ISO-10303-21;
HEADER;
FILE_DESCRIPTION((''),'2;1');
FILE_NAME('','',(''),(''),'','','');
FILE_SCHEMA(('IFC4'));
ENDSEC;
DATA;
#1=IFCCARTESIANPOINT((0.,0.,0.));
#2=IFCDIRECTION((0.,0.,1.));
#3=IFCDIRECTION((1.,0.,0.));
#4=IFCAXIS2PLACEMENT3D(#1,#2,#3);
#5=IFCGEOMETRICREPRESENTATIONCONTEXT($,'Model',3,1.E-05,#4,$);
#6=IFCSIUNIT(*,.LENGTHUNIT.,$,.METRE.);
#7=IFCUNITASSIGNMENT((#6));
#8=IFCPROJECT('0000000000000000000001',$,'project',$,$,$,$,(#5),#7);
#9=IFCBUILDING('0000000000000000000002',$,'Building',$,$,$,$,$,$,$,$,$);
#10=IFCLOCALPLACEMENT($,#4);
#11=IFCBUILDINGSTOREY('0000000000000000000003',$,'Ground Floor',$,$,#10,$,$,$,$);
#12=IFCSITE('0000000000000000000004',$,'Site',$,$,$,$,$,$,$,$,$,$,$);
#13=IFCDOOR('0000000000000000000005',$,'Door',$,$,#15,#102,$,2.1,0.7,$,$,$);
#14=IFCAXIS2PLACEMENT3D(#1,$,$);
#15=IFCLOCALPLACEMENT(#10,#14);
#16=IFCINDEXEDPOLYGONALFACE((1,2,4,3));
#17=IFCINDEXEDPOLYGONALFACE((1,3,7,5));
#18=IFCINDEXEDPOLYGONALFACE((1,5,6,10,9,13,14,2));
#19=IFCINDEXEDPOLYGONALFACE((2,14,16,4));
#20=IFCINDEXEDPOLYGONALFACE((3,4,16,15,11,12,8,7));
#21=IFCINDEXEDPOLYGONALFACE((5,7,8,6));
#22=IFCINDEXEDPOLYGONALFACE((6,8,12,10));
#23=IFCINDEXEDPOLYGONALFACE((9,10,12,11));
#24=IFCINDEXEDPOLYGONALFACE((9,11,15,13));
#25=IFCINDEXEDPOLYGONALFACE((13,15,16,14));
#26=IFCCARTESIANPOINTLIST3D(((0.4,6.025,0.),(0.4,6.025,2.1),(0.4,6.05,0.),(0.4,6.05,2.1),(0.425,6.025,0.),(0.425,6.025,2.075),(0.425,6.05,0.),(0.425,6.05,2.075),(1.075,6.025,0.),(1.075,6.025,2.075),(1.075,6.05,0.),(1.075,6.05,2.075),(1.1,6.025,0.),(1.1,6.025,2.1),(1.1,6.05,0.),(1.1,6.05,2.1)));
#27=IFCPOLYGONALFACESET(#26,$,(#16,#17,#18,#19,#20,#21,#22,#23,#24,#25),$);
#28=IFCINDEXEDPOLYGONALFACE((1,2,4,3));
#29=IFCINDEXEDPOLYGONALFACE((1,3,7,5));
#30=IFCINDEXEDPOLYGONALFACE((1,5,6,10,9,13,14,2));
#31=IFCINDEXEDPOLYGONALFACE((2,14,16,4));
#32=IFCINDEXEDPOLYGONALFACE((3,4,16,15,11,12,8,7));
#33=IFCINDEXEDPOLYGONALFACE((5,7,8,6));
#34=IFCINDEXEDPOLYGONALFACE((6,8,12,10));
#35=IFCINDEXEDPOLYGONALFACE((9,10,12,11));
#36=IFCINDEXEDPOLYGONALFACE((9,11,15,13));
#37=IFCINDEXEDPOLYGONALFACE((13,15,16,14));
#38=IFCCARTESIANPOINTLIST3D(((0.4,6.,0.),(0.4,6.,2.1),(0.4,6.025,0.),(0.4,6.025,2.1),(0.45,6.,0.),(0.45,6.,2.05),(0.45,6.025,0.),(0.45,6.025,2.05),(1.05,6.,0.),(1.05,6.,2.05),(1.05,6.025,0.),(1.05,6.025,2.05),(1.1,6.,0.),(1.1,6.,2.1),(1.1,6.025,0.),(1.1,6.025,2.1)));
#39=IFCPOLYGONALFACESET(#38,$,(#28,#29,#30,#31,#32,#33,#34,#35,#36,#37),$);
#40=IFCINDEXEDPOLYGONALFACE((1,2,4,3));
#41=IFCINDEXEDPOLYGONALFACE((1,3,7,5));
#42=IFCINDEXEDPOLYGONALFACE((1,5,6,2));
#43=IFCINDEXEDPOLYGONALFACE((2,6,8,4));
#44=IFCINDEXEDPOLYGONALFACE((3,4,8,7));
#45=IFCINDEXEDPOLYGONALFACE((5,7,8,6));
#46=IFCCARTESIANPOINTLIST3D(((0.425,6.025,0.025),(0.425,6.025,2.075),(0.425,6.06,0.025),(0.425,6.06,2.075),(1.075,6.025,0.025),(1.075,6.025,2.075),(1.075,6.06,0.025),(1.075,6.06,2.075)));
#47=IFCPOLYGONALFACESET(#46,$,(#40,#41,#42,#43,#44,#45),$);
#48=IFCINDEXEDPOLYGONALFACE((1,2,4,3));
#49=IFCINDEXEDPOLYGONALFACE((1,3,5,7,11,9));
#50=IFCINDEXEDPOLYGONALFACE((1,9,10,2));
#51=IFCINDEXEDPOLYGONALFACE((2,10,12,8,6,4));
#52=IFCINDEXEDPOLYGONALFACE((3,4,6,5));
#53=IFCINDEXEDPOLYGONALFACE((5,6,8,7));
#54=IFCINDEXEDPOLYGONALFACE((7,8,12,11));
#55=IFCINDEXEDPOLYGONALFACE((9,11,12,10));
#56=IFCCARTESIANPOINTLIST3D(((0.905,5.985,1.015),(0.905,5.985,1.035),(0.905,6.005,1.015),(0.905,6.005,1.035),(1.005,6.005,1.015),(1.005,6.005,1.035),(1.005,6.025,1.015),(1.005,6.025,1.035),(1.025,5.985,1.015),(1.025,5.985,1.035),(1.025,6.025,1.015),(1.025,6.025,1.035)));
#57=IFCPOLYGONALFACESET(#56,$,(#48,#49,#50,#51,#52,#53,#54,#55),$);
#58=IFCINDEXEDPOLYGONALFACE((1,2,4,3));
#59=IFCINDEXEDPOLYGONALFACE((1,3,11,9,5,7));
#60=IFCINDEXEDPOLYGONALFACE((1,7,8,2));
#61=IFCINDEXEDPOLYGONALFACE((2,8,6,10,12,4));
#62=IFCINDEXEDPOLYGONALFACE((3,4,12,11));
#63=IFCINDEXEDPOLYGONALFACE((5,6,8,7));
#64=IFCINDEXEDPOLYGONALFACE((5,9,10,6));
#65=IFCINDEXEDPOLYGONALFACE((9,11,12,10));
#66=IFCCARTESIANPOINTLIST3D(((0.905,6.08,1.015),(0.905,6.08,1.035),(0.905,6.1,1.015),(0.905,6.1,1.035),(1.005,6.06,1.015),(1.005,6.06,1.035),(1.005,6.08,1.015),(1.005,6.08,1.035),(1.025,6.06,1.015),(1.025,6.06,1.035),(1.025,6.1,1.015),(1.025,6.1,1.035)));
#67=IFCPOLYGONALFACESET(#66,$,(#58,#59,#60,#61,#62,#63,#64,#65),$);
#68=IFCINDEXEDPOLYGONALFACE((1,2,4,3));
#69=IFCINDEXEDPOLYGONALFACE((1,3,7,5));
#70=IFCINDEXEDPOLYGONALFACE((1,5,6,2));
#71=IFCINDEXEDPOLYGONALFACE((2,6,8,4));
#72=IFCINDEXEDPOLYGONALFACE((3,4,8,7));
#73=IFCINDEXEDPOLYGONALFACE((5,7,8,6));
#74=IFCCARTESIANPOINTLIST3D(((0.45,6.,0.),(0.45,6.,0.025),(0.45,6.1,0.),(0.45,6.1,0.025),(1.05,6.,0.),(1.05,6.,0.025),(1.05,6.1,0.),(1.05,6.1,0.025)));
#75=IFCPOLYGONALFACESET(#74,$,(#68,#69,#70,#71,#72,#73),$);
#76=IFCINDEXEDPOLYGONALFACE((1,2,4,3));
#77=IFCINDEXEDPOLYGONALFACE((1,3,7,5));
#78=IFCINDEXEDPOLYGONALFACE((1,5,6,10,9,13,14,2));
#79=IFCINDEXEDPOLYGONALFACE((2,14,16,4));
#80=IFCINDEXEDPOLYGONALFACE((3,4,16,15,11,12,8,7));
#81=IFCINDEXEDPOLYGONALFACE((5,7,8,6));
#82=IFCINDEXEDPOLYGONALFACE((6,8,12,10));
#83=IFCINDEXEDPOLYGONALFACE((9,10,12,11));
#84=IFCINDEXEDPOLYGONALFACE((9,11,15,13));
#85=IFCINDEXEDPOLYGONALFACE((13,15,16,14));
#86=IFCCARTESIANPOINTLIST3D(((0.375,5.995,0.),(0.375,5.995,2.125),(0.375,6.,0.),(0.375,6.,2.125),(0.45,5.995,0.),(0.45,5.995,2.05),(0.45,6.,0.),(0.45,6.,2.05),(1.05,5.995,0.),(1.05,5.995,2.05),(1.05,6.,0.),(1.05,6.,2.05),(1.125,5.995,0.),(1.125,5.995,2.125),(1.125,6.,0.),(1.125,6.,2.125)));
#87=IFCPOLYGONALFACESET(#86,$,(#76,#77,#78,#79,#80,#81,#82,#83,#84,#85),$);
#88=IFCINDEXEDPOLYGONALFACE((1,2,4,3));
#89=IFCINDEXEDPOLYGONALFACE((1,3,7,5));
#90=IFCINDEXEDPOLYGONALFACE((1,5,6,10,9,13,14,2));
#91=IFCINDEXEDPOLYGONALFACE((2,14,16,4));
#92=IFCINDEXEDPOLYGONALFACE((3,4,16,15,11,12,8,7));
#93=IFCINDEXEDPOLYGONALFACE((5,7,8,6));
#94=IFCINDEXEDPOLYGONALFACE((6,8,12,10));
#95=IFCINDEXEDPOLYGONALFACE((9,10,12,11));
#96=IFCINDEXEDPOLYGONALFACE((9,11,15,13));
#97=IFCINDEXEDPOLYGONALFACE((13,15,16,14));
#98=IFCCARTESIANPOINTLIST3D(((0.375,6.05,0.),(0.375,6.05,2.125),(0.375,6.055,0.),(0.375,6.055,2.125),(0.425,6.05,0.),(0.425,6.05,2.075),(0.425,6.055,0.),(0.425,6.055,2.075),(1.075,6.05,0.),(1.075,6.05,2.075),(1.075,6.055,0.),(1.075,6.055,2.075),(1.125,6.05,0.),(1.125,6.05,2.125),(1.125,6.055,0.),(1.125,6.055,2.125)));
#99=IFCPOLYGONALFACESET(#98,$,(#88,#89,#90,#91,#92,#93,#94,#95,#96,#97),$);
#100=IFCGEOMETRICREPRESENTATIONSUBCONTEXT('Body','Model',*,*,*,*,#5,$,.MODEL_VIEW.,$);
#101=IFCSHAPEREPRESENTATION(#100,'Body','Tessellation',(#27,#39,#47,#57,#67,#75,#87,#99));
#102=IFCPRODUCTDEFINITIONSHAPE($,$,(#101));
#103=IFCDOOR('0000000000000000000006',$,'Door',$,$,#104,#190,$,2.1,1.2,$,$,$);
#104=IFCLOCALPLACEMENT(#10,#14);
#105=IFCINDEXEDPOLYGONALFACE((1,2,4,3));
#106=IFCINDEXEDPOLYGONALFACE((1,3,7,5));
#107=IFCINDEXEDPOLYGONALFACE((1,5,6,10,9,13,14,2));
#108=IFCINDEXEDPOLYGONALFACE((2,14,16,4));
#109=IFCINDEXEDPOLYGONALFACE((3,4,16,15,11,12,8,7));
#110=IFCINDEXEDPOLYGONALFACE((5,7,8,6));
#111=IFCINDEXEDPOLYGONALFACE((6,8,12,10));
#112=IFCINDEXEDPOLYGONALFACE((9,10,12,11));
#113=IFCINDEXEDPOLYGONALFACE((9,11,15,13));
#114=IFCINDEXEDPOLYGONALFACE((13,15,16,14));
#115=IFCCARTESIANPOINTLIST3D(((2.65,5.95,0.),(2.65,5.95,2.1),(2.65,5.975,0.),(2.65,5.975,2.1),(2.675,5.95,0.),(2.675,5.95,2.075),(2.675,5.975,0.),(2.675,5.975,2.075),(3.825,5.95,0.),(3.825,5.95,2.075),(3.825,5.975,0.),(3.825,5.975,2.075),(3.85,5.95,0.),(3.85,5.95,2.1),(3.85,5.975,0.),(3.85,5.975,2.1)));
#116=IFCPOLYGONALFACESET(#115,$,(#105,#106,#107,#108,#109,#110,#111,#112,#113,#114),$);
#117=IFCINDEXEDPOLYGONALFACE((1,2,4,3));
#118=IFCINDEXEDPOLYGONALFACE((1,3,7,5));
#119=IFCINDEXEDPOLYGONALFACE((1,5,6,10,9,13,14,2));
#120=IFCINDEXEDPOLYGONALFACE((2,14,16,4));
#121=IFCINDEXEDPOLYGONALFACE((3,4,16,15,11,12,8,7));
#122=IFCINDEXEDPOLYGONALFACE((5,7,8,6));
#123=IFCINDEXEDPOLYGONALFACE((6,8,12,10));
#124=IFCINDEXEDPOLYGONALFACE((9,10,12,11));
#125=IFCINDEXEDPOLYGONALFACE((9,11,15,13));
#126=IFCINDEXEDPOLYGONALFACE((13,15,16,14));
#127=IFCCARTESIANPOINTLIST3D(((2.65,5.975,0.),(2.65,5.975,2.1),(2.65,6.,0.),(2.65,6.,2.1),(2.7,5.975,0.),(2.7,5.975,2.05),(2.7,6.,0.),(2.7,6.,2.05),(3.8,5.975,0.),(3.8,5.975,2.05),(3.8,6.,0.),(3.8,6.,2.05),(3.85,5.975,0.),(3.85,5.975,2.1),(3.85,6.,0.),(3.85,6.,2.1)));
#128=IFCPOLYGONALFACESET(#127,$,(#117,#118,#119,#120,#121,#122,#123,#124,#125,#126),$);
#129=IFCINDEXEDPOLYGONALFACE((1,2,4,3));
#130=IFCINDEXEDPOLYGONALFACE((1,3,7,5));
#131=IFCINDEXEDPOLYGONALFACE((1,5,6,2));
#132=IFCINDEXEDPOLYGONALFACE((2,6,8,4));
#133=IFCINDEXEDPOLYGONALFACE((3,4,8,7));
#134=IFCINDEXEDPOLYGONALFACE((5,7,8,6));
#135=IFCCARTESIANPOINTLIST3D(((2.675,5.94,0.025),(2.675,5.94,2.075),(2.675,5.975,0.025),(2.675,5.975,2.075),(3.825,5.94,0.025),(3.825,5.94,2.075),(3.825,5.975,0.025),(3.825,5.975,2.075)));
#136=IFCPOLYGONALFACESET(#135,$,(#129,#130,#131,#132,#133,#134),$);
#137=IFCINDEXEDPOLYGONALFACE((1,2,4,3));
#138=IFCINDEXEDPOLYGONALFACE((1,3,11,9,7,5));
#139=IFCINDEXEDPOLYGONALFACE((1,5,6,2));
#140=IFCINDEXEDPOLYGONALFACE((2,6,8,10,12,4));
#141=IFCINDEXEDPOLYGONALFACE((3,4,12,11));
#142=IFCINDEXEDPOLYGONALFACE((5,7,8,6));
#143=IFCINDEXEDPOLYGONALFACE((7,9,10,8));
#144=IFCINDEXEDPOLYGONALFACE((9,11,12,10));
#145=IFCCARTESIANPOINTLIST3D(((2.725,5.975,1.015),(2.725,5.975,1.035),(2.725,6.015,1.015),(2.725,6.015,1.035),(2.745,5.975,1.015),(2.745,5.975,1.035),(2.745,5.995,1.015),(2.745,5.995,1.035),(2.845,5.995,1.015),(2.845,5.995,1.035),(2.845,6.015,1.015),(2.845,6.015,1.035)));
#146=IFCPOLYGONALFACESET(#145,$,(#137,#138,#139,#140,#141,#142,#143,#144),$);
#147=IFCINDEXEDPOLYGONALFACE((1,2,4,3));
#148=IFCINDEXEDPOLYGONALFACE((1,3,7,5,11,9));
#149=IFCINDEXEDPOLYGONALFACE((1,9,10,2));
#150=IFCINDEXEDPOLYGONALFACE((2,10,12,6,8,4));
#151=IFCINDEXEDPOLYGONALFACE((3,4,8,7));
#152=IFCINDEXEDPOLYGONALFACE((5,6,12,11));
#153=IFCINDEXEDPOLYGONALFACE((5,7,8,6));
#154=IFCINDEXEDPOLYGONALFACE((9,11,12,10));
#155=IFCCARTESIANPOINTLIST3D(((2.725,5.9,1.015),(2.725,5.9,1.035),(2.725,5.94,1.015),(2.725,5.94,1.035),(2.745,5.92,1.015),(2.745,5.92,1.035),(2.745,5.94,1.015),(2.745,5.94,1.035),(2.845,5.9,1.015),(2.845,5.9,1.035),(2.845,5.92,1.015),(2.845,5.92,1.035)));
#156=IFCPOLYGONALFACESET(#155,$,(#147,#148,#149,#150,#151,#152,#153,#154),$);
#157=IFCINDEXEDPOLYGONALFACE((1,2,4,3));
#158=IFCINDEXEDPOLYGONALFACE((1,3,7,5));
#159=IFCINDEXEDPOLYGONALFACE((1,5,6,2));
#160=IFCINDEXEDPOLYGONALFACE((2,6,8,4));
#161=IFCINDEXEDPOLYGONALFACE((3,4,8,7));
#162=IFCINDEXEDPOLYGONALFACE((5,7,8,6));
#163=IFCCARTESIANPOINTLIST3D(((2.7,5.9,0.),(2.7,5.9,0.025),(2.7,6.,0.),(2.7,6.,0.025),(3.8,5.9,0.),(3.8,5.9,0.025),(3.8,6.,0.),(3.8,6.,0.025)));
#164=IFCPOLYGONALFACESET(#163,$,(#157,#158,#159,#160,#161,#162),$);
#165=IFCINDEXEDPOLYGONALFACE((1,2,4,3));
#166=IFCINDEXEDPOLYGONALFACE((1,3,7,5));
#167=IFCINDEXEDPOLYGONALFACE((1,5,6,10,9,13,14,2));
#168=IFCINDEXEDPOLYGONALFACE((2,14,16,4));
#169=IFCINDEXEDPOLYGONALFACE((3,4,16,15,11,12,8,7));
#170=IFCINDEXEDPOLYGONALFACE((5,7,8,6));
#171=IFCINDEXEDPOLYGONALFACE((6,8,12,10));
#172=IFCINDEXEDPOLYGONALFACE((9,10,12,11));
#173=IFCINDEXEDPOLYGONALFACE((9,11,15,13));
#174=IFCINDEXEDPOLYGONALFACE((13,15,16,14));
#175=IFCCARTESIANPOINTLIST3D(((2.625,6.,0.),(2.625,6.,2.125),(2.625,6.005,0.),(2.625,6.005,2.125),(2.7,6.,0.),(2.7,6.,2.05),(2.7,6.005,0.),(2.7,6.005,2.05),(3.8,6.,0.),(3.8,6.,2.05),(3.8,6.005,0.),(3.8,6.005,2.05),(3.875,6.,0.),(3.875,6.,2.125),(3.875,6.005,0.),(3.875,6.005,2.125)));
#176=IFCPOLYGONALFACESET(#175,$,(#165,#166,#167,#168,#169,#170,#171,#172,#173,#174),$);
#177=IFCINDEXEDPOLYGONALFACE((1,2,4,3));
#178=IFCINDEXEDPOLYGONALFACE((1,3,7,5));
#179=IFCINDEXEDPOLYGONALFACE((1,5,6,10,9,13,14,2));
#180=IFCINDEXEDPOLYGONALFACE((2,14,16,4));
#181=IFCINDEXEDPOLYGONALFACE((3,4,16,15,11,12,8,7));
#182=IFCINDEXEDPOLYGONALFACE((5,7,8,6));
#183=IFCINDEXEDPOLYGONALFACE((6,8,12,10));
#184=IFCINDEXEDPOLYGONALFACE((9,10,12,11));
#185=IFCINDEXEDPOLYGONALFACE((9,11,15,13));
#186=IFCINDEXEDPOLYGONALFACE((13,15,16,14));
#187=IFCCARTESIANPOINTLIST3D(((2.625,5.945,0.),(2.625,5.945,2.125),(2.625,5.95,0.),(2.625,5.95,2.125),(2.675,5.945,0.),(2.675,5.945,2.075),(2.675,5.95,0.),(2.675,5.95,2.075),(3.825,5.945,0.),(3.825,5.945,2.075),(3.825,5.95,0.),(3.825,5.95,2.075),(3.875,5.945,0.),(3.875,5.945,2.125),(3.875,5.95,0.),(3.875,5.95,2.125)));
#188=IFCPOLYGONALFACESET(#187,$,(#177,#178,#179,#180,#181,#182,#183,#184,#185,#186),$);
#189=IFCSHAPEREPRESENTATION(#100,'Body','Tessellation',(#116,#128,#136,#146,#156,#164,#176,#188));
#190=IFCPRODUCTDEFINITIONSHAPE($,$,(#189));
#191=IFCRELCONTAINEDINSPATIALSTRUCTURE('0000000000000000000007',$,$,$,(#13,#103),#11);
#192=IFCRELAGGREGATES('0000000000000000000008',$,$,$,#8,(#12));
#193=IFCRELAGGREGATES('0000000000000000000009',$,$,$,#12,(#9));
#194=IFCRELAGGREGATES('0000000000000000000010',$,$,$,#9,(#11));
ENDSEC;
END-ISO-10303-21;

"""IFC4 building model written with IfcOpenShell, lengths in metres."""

from ifc_helpers import new_model, si_unit, frame, origin_with_axes, place, context, subcontext, project, spatial, line, indexed_curve, outline, extrude, element, save


model = new_model("IFC4")

# Units and contexts
model_context = context("Model", 3, precision=1e-05, world=origin_with_axes())
body_context = subcontext(model_context, "Body", "Model", "MODEL_VIEW")
ifc_project = project(units=[si_unit("LENGTHUNIT", "METRE")], contexts=[model_context])

# Site, building, storey
site = spatial("IfcSite", under=ifc_project, Name="Site")
building = spatial("IfcBuilding", under=site, Name="Building")
storey_placement = place(None, origin_with_axes())
storey = spatial("IfcBuildingStorey", under=building, at=storey_placement, Name="Ground Floor")

# Doors
door_1_placement = place(storey_placement, frame((0.4, 6.0, 0.0), z_axis=(0.0, 0.0, 1.0), x_axis=(1.0, 0.0, 0.0)))
element("IfcDoor", 1, at=door_1_placement, inside=storey, Name="Door", OverallHeight=2.1, OverallWidth=0.7, context=body_context, shape_type="SweptSolid", body=[
    extrude(outline(indexed_curve([(0.0, 0.0), (0.0, 2.1), (0.7, 2.1), (0.7, 0.0), (0.675, 0.0), (0.675, 2.075), (0.025, 2.075), (0.025, 0.0)], segments=[line(1, 2, 3, 4, 5, 6, 7, 8, 1)])), frame((0.0, 0.025, 0.0), z_axis=(0.0, -1.0, 0.0), x_axis=(1.0, 0.0, 0.0)), (0.0, 0.0, -1.0), 0.025),
    extrude(outline(indexed_curve([(0.0, 0.0), (0.0, 2.1), (0.7, 2.1), (0.7, 0.0), (0.65, 0.0), (0.65, 2.05), (0.05, 2.05), (0.05, 0.0)], segments=[line(1, 2, 3, 4, 5, 6, 7, 8, 1)])), frame((0.0, 0.0, 0.0), z_axis=(0.0, -1.0, 0.0), x_axis=(1.0, 0.0, 0.0)), (0.0, 0.0, -1.0), 0.025),
    extrude(outline(indexed_curve([(0.0, 0.0), (0.65, 0.0), (0.65, 0.035), (0.0, 0.035)], segments=[line(1, 2, 3, 4, 1)])), frame((0.025, 0.025, 0.025), z_axis=(0.0, 0.0, 1.0), x_axis=(1.0, 0.0, 0.0)), (0.0, 0.0, 1.0), 2.05),
    extrude(outline(indexed_curve([(0.0, 0.0), (0.0, -0.04), (-0.12, -0.04), (-0.12, -0.02), (-0.02, -0.02), (-0.02, 0.0)], segments=[line(1, 2, 3, 4, 5, 6, 1)])), frame((0.625, 0.025, 1.015), z_axis=(0.0, 0.0, 1.0), x_axis=(1.0, 0.0, 0.0)), (0.0, 0.0, 1.0), 0.02),
    extrude(outline(indexed_curve([(0.0, 0.0), (0.0, 0.04), (-0.12, 0.04), (-0.12, 0.02), (-0.02, 0.02), (-0.02, 0.0)], segments=[line(1, 2, 3, 4, 5, 6, 1)])), frame((0.625, 0.06, 1.015), z_axis=(0.0, 0.0, 1.0), x_axis=(1.0, 0.0, 0.0)), (0.0, 0.0, 1.0), 0.02),
    extrude(outline(indexed_curve([(0.0, 0.0), (0.6, 0.0), (0.6, 0.1), (0.0, 0.1)], segments=[line(1, 2, 3, 4, 1)])), frame((0.05, 0.0, 0.0), z_axis=(0.0, 0.0, 1.0), x_axis=(1.0, 0.0, 0.0)), (0.0, 0.0, 1.0), 0.025),
    extrude(outline(indexed_curve([(0.0, 0.0), (0.0, 2.125), (0.75, 2.125), (0.75, 0.0), (0.675, 0.0), (0.675, 2.05), (0.075, 2.05), (0.075, 0.0)], segments=[line(1, 2, 3, 4, 5, 6, 7, 8, 1)])), frame((-0.025, -0.005, 0.0), z_axis=(0.0, -1.0, 0.0), x_axis=(1.0, 0.0, 0.0)), (0.0, 0.0, -1.0), 0.005),
    extrude(outline(indexed_curve([(0.0, 0.0), (0.0, 2.125), (0.75, 2.125), (0.75, 0.0), (0.7, 0.0), (0.7, 2.075), (0.05, 2.075), (0.05, 0.0)], segments=[line(1, 2, 3, 4, 5, 6, 7, 8, 1)])), frame((-0.025, 0.05, 0.0), z_axis=(0.0, -1.0, 0.0), x_axis=(1.0, 0.0, 0.0)), (0.0, 0.0, -1.0), 0.005),
])
door_2_placement = place(storey_placement, frame((3.85, 6.0, 0.0), z_axis=(0.0, 0.0, 1.0), x_axis=(-1.0, 0.0, 0.0)))
element("IfcDoor", 2, at=door_2_placement, inside=storey, Name="Door", OverallHeight=2.1, OverallWidth=1.2, context=body_context, shape_type="SweptSolid", body=[
    extrude(outline(indexed_curve([(0.0, 0.0), (0.0, 2.1), (1.2, 2.1), (1.2, 0.0), (1.175, 0.0), (1.175, 2.075), (0.025, 2.075), (0.025, 0.0)], segments=[line(1, 2, 3, 4, 5, 6, 7, 8, 1)])), frame((0.0, 0.025, 0.0), z_axis=(0.0, -1.0, 0.0), x_axis=(1.0, 0.0, 0.0)), (0.0, 0.0, -1.0), 0.025),
    extrude(outline(indexed_curve([(0.0, 0.0), (0.0, 2.1), (1.2, 2.1), (1.2, 0.0), (1.15, 0.0), (1.15, 2.05), (0.05, 2.05), (0.05, 0.0)], segments=[line(1, 2, 3, 4, 5, 6, 7, 8, 1)])), frame((0.0, 0.0, 0.0), z_axis=(0.0, -1.0, 0.0), x_axis=(1.0, 0.0, 0.0)), (0.0, 0.0, -1.0), 0.025),
    extrude(outline(indexed_curve([(0.0, 0.0), (1.15, 0.0), (1.15, 0.035), (0.0, 0.035)], segments=[line(1, 2, 3, 4, 1)])), frame((0.025, 0.025, 0.025), z_axis=(0.0, 0.0, 1.0), x_axis=(1.0, 0.0, 0.0)), (0.0, 0.0, 1.0), 2.05),
    extrude(outline(indexed_curve([(0.0, 0.0), (0.0, -0.04), (-0.12, -0.04), (-0.12, -0.02), (-0.02, -0.02), (-0.02, 0.0)], segments=[line(1, 2, 3, 4, 5, 6, 1)])), frame((1.125, 0.025, 1.015), z_axis=(0.0, 0.0, 1.0), x_axis=(1.0, 0.0, 0.0)), (0.0, 0.0, 1.0), 0.02),
    extrude(outline(indexed_curve([(0.0, 0.0), (0.0, 0.04), (-0.12, 0.04), (-0.12, 0.02), (-0.02, 0.02), (-0.02, 0.0)], segments=[line(1, 2, 3, 4, 5, 6, 1)])), frame((1.125, 0.06, 1.015), z_axis=(0.0, 0.0, 1.0), x_axis=(1.0, 0.0, 0.0)), (0.0, 0.0, 1.0), 0.02),
    extrude(outline(indexed_curve([(0.0, 0.0), (1.1, 0.0), (1.1, 0.1), (0.0, 0.1)], segments=[line(1, 2, 3, 4, 1)])), frame((0.05, 0.0, 0.0), z_axis=(0.0, 0.0, 1.0), x_axis=(1.0, 0.0, 0.0)), (0.0, 0.0, 1.0), 0.025),
    extrude(outline(indexed_curve([(0.0, 0.0), (0.0, 2.125), (1.25, 2.125), (1.25, 0.0), (1.175, 0.0), (1.175, 2.05), (0.075, 2.05), (0.075, 0.0)], segments=[line(1, 2, 3, 4, 5, 6, 7, 8, 1)])), frame((-0.025, -0.005, 0.0), z_axis=(0.0, -1.0, 0.0), x_axis=(1.0, 0.0, 0.0)), (0.0, 0.0, -1.0), 0.005),
    extrude(outline(indexed_curve([(0.0, 0.0), (0.0, 2.125), (1.25, 2.125), (1.25, 0.0), (1.2, 0.0), (1.2, 2.075), (0.05, 2.075), (0.05, 0.0)], segments=[line(1, 2, 3, 4, 5, 6, 7, 8, 1)])), frame((-0.025, 0.05, 0.0), z_axis=(0.0, -1.0, 0.0), x_axis=(1.0, 0.0, 0.0)), (0.0, 0.0, -1.0), 0.005),
])

save(model, "model.ifc")
